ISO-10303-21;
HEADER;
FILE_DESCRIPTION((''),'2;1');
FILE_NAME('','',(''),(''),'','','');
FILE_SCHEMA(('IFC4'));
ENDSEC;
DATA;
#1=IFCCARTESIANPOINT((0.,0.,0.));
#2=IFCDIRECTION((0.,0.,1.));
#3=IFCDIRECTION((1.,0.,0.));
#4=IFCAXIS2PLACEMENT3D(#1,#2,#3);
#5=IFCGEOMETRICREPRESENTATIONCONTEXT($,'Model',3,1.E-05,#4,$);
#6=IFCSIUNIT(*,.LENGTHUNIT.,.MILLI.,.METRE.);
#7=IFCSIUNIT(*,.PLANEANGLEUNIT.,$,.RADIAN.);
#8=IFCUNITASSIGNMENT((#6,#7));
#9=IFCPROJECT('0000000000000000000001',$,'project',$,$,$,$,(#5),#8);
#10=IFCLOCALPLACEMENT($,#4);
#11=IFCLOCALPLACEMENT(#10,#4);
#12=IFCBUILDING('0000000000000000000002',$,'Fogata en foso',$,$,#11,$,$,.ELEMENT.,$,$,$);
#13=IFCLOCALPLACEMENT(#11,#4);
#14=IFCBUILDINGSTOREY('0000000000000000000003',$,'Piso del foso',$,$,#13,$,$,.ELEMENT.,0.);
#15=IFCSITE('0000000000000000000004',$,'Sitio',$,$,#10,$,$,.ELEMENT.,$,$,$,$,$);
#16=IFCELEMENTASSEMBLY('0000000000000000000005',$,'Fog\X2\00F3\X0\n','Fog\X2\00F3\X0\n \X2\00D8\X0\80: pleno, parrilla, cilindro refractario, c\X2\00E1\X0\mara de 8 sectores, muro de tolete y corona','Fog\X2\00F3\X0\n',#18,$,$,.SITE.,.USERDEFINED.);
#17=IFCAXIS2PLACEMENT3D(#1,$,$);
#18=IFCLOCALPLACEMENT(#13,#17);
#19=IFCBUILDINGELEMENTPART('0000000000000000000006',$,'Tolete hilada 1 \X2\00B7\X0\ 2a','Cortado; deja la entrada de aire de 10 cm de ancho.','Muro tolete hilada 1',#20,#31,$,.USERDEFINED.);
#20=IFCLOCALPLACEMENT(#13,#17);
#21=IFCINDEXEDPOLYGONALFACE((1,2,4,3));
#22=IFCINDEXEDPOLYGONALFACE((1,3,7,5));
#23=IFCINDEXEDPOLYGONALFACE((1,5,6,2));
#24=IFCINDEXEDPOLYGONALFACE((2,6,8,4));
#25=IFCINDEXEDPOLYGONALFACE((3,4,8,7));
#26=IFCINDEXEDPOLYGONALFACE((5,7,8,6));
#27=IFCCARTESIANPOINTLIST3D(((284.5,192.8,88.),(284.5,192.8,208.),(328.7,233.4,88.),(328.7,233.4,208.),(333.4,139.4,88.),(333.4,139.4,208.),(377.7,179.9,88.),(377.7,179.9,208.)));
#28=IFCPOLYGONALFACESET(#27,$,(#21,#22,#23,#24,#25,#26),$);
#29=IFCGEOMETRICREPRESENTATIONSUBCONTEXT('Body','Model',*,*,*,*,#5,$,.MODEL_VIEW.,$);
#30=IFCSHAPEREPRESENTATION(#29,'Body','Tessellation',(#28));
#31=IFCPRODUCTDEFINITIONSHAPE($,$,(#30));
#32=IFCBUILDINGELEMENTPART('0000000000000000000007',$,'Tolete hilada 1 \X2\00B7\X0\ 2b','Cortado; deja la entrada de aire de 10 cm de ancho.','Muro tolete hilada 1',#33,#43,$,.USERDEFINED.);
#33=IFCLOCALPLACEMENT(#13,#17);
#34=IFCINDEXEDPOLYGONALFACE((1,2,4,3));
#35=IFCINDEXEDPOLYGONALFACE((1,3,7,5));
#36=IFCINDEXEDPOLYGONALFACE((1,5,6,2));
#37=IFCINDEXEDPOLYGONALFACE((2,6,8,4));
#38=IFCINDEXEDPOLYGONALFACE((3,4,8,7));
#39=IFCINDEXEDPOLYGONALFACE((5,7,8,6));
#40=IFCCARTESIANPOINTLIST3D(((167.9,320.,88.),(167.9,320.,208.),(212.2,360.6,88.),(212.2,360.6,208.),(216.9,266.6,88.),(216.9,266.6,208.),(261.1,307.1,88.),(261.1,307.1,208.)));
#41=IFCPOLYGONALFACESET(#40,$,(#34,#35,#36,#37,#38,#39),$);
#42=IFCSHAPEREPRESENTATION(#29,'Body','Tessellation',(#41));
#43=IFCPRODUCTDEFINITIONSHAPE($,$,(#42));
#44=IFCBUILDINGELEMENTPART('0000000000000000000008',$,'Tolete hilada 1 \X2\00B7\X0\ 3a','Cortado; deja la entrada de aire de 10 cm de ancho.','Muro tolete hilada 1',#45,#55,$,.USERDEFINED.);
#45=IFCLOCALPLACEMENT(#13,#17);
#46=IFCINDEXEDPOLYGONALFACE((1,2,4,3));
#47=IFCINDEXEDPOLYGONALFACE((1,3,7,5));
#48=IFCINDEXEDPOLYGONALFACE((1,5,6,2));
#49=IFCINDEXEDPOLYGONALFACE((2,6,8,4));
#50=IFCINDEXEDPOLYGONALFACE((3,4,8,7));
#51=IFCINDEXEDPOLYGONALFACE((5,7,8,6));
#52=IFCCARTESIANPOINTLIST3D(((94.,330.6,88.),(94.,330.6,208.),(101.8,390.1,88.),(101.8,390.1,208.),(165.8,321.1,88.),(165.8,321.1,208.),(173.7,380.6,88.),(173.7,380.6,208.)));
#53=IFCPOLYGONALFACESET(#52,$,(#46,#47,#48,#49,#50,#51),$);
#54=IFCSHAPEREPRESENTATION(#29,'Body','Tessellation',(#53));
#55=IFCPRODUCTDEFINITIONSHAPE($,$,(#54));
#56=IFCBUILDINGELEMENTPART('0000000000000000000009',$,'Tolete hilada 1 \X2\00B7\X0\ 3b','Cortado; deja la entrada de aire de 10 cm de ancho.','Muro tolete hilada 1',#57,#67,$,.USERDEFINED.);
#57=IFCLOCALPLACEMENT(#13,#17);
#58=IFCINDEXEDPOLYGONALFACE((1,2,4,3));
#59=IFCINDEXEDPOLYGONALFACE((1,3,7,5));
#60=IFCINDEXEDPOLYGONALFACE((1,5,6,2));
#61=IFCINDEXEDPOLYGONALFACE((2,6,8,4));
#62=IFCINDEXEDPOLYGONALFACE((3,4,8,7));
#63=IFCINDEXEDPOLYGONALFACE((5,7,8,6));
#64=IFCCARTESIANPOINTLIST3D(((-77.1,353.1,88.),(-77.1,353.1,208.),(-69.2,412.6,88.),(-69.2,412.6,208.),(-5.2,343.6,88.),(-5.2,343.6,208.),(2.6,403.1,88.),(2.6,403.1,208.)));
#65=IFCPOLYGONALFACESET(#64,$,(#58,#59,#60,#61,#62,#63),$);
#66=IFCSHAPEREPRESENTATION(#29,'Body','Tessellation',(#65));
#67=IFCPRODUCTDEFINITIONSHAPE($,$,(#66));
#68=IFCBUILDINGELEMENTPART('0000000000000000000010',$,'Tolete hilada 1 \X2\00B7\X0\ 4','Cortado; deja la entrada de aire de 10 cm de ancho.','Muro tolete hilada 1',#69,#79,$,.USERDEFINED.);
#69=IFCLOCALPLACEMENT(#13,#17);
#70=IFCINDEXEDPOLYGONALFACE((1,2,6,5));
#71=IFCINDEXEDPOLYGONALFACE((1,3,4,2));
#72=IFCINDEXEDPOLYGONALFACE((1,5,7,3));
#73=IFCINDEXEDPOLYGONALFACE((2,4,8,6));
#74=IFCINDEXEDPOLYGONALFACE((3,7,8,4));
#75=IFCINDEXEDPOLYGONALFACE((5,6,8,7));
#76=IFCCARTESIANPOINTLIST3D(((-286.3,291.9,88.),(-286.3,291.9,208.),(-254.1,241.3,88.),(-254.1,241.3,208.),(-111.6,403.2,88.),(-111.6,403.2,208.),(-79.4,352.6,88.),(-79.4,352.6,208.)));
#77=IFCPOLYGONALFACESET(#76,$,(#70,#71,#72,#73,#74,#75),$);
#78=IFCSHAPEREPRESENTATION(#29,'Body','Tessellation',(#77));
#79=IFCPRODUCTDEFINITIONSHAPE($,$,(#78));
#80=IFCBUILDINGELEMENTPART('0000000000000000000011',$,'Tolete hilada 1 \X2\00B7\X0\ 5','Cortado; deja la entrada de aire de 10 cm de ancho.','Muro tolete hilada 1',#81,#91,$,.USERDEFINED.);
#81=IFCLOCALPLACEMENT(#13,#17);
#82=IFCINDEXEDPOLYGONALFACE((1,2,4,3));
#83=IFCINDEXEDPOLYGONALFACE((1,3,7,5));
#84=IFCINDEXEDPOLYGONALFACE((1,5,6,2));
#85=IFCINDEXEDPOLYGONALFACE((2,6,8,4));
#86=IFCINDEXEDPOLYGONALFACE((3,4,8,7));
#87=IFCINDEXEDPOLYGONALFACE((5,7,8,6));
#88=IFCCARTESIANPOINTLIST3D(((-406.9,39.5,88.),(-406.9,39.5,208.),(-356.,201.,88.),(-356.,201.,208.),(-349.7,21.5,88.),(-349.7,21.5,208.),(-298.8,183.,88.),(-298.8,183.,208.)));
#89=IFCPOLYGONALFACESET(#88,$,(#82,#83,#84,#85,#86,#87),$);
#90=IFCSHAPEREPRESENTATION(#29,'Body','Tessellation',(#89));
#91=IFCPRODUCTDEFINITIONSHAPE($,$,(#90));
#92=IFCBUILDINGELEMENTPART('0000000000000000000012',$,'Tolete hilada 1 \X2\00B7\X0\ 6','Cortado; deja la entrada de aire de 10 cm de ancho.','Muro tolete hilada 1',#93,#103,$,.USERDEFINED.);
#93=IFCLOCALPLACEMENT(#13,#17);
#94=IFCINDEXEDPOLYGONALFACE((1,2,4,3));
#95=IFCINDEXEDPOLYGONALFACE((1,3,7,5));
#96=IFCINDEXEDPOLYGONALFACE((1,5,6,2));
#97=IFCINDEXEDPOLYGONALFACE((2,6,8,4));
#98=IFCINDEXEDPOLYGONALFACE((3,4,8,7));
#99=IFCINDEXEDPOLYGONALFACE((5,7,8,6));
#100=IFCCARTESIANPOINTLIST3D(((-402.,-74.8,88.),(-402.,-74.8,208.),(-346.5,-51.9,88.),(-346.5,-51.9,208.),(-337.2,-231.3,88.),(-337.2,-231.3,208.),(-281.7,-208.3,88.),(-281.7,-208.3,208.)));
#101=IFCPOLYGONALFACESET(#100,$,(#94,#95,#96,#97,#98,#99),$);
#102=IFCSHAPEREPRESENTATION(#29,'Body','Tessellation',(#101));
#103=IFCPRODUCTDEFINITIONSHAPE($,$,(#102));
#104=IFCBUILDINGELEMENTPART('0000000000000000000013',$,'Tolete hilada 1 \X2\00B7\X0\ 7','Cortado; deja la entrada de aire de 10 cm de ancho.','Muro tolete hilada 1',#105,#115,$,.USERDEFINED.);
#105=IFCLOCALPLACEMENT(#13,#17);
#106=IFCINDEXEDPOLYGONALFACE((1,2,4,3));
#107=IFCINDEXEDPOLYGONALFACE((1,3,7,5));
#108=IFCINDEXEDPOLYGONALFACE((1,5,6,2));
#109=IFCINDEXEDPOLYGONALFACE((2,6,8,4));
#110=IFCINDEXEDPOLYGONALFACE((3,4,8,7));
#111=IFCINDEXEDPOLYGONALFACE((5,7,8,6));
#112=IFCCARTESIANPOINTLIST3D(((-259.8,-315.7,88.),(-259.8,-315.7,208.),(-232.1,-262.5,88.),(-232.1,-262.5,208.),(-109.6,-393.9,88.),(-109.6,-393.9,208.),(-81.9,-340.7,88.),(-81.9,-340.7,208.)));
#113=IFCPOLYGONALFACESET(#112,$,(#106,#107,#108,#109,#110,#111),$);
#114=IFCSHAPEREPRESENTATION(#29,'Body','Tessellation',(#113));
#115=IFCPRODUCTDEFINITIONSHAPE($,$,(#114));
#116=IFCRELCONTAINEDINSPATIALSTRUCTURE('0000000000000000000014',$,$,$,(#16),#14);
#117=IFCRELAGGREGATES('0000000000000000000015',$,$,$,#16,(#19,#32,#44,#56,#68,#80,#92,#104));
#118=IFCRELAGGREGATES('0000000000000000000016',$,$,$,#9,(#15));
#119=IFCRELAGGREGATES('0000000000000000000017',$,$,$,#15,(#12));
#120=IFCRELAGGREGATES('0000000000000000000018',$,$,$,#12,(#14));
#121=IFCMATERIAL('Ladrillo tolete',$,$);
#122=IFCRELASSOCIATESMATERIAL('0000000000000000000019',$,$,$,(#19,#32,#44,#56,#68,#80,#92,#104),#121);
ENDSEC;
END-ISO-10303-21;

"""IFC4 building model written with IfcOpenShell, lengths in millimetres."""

from ifc_helpers import new_model, si_unit, frame, origin_with_axes, place, context, subcontext, project, spatial, polyline, outline, extrude, material, element, aggregate, save


model = new_model("IFC4")

# Units and contexts
model_context = context("Model", 3, precision=1e-05, world=origin_with_axes())
body_context = subcontext(model_context, "Body", "Model", "MODEL_VIEW")
ifc_project = project(units=[si_unit("LENGTHUNIT", "METRE", prefix="MILLI"), si_unit("PLANEANGLEUNIT", "RADIAN")], contexts=[model_context])

# Site, building, storey
site_placement = place(None, origin_with_axes())
site = spatial("IfcSite", under=ifc_project, at=site_placement, Name="Sitio", CompositionType="ELEMENT")
building_placement = place(site_placement, origin_with_axes())
building = spatial("IfcBuilding", under=site, at=building_placement, Name="Fogata en foso", CompositionType="ELEMENT")
storey_placement = place(building_placement, origin_with_axes())
storey = spatial("IfcBuildingStorey", under=building, at=storey_placement, Name="Piso del foso", CompositionType="ELEMENT", Elevation=0.0)

# Element assembly, building element parts
assembly_1_placement = place(storey_placement, origin_with_axes())
assembly_1 = element("IfcElementAssembly", 1, at=assembly_1_placement, inside=storey, Name="Fogón", Description="Fogón Ø80: pleno, parrilla, cilindro refractario, cámara de 8 sectores, muro de tolete y corona", ObjectType="Fogón", AssemblyPlace="SITE", PredefinedType="USERDEFINED")
ifc_material_1 = material(Name="Ladrillo tolete")
building_element_part_1_placement = place(storey_placement, frame((0.0, 0.0, 88.0), z_axis=(0.0, 0.0, 1.0), x_axis=(1.0, 0.0, 0.0)))
building_element_part_1 = element("IfcBuildingElementPart", 2, at=building_element_part_1_placement, material=ifc_material_1, Name="Tolete hilada 1 · 2a", Description="Cortado; deja la entrada de aire de 10 cm de ancho.", ObjectType="Muro tolete hilada 1", PredefinedType="USERDEFINED", context=body_context, shape_type="SweptSolid", body=[
    extrude(outline(polyline([(377.7, 179.9), (328.7, 233.4), (284.5, 192.8), (333.4, 139.4), (377.7, 179.9)])), origin_with_axes(), (0.0, 0.0, 1.0), 120.0),
])
building_element_part_2_placement = place(storey_placement, frame((0.0, 0.0, 88.0), z_axis=(0.0, 0.0, 1.0), x_axis=(1.0, 0.0, 0.0)))
building_element_part_2 = element("IfcBuildingElementPart", 3, at=building_element_part_2_placement, material=ifc_material_1, Name="Tolete hilada 1 · 2b", Description="Cortado; deja la entrada de aire de 10 cm de ancho.", ObjectType="Muro tolete hilada 1", PredefinedType="USERDEFINED", context=body_context, shape_type="SweptSolid", body=[
    extrude(outline(polyline([(261.1, 307.1), (212.2, 360.6), (167.9, 320.0), (216.9, 266.6), (261.1, 307.1)])), origin_with_axes(), (0.0, 0.0, 1.0), 120.0),
])
building_element_part_3_placement = place(storey_placement, frame((0.0, 0.0, 88.0), z_axis=(0.0, 0.0, 1.0), x_axis=(1.0, 0.0, 0.0)))
building_element_part_3 = element("IfcBuildingElementPart", 4, at=building_element_part_3_placement, material=ifc_material_1, Name="Tolete hilada 1 · 3a", Description="Cortado; deja la entrada de aire de 10 cm de ancho.", ObjectType="Muro tolete hilada 1", PredefinedType="USERDEFINED", context=body_context, shape_type="SweptSolid", body=[
    extrude(outline(polyline([(173.7, 380.6), (101.8, 390.1), (94.0, 330.6), (165.8, 321.1), (173.7, 380.6)])), origin_with_axes(), (0.0, 0.0, 1.0), 120.0),
])
building_element_part_4_placement = place(storey_placement, frame((0.0, 0.0, 88.0), z_axis=(0.0, 0.0, 1.0), x_axis=(1.0, 0.0, 0.0)))
building_element_part_4 = element("IfcBuildingElementPart", 5, at=building_element_part_4_placement, material=ifc_material_1, Name="Tolete hilada 1 · 3b", Description="Cortado; deja la entrada de aire de 10 cm de ancho.", ObjectType="Muro tolete hilada 1", PredefinedType="USERDEFINED", context=body_context, shape_type="SweptSolid", body=[
    extrude(outline(polyline([(2.6, 403.1), (-69.2, 412.6), (-77.1, 353.1), (-5.2, 343.6), (2.6, 403.1)])), origin_with_axes(), (0.0, 0.0, 1.0), 120.0),
])
building_element_part_5_placement = place(storey_placement, frame((0.0, 0.0, 88.0), z_axis=(0.0, 0.0, 1.0), x_axis=(1.0, 0.0, 0.0)))
building_element_part_5 = element("IfcBuildingElementPart", 6, at=building_element_part_5_placement, material=ifc_material_1, Name="Tolete hilada 1 · 4", Description="Cortado; deja la entrada de aire de 10 cm de ancho.", ObjectType="Muro tolete hilada 1", PredefinedType="USERDEFINED", context=body_context, shape_type="SweptSolid", body=[
    extrude(outline(polyline([(-111.6, 403.2), (-286.3, 291.9), (-254.1, 241.3), (-79.4, 352.6), (-111.6, 403.2)])), origin_with_axes(), (0.0, 0.0, 1.0), 120.0),
])
building_element_part_6_placement = place(storey_placement, frame((0.0, 0.0, 88.0), z_axis=(0.0, 0.0, 1.0), x_axis=(1.0, 0.0, 0.0)))
building_element_part_6 = element("IfcBuildingElementPart", 7, at=building_element_part_6_placement, material=ifc_material_1, Name="Tolete hilada 1 · 5", Description="Cortado; deja la entrada de aire de 10 cm de ancho.", ObjectType="Muro tolete hilada 1", PredefinedType="USERDEFINED", context=body_context, shape_type="SweptSolid", body=[
    extrude(outline(polyline([(-356.0, 201.0), (-406.9, 39.5), (-349.7, 21.5), (-298.8, 183.0), (-356.0, 201.0)])), origin_with_axes(), (0.0, 0.0, 1.0), 120.0),
])
building_element_part_7_placement = place(storey_placement, frame((0.0, 0.0, 88.0), z_axis=(0.0, 0.0, 1.0), x_axis=(1.0, 0.0, 0.0)))
building_element_part_7 = element("IfcBuildingElementPart", 8, at=building_element_part_7_placement, material=ifc_material_1, Name="Tolete hilada 1 · 6", Description="Cortado; deja la entrada de aire de 10 cm de ancho.", ObjectType="Muro tolete hilada 1", PredefinedType="USERDEFINED", context=body_context, shape_type="SweptSolid", body=[
    extrude(outline(polyline([(-402.0, -74.8), (-337.1, -231.3), (-281.7, -208.3), (-346.5, -51.9), (-402.0, -74.8)])), origin_with_axes(), (0.0, 0.0, 1.0), 120.0),
])
building_element_part_8_placement = place(storey_placement, frame((0.0, 0.0, 88.0), z_axis=(0.0, 0.0, 1.0), x_axis=(1.0, 0.0, 0.0)))
building_element_part_8 = element("IfcBuildingElementPart", 9, at=building_element_part_8_placement, material=ifc_material_1, Name="Tolete hilada 1 · 7", Description="Cortado; deja la entrada de aire de 10 cm de ancho.", ObjectType="Muro tolete hilada 1", PredefinedType="USERDEFINED", context=body_context, shape_type="SweptSolid", body=[
    extrude(outline(polyline([(-259.8, -315.7), (-109.6, -393.9), (-81.9, -340.7), (-232.1, -262.5), (-259.8, -315.7)])), origin_with_axes(), (0.0, 0.0, 1.0), 120.0),
])
aggregate(assembly_1, [building_element_part_1, building_element_part_2, building_element_part_3, building_element_part_4, building_element_part_5, building_element_part_6, building_element_part_7, building_element_part_8])

save(model, "model.ifc")
